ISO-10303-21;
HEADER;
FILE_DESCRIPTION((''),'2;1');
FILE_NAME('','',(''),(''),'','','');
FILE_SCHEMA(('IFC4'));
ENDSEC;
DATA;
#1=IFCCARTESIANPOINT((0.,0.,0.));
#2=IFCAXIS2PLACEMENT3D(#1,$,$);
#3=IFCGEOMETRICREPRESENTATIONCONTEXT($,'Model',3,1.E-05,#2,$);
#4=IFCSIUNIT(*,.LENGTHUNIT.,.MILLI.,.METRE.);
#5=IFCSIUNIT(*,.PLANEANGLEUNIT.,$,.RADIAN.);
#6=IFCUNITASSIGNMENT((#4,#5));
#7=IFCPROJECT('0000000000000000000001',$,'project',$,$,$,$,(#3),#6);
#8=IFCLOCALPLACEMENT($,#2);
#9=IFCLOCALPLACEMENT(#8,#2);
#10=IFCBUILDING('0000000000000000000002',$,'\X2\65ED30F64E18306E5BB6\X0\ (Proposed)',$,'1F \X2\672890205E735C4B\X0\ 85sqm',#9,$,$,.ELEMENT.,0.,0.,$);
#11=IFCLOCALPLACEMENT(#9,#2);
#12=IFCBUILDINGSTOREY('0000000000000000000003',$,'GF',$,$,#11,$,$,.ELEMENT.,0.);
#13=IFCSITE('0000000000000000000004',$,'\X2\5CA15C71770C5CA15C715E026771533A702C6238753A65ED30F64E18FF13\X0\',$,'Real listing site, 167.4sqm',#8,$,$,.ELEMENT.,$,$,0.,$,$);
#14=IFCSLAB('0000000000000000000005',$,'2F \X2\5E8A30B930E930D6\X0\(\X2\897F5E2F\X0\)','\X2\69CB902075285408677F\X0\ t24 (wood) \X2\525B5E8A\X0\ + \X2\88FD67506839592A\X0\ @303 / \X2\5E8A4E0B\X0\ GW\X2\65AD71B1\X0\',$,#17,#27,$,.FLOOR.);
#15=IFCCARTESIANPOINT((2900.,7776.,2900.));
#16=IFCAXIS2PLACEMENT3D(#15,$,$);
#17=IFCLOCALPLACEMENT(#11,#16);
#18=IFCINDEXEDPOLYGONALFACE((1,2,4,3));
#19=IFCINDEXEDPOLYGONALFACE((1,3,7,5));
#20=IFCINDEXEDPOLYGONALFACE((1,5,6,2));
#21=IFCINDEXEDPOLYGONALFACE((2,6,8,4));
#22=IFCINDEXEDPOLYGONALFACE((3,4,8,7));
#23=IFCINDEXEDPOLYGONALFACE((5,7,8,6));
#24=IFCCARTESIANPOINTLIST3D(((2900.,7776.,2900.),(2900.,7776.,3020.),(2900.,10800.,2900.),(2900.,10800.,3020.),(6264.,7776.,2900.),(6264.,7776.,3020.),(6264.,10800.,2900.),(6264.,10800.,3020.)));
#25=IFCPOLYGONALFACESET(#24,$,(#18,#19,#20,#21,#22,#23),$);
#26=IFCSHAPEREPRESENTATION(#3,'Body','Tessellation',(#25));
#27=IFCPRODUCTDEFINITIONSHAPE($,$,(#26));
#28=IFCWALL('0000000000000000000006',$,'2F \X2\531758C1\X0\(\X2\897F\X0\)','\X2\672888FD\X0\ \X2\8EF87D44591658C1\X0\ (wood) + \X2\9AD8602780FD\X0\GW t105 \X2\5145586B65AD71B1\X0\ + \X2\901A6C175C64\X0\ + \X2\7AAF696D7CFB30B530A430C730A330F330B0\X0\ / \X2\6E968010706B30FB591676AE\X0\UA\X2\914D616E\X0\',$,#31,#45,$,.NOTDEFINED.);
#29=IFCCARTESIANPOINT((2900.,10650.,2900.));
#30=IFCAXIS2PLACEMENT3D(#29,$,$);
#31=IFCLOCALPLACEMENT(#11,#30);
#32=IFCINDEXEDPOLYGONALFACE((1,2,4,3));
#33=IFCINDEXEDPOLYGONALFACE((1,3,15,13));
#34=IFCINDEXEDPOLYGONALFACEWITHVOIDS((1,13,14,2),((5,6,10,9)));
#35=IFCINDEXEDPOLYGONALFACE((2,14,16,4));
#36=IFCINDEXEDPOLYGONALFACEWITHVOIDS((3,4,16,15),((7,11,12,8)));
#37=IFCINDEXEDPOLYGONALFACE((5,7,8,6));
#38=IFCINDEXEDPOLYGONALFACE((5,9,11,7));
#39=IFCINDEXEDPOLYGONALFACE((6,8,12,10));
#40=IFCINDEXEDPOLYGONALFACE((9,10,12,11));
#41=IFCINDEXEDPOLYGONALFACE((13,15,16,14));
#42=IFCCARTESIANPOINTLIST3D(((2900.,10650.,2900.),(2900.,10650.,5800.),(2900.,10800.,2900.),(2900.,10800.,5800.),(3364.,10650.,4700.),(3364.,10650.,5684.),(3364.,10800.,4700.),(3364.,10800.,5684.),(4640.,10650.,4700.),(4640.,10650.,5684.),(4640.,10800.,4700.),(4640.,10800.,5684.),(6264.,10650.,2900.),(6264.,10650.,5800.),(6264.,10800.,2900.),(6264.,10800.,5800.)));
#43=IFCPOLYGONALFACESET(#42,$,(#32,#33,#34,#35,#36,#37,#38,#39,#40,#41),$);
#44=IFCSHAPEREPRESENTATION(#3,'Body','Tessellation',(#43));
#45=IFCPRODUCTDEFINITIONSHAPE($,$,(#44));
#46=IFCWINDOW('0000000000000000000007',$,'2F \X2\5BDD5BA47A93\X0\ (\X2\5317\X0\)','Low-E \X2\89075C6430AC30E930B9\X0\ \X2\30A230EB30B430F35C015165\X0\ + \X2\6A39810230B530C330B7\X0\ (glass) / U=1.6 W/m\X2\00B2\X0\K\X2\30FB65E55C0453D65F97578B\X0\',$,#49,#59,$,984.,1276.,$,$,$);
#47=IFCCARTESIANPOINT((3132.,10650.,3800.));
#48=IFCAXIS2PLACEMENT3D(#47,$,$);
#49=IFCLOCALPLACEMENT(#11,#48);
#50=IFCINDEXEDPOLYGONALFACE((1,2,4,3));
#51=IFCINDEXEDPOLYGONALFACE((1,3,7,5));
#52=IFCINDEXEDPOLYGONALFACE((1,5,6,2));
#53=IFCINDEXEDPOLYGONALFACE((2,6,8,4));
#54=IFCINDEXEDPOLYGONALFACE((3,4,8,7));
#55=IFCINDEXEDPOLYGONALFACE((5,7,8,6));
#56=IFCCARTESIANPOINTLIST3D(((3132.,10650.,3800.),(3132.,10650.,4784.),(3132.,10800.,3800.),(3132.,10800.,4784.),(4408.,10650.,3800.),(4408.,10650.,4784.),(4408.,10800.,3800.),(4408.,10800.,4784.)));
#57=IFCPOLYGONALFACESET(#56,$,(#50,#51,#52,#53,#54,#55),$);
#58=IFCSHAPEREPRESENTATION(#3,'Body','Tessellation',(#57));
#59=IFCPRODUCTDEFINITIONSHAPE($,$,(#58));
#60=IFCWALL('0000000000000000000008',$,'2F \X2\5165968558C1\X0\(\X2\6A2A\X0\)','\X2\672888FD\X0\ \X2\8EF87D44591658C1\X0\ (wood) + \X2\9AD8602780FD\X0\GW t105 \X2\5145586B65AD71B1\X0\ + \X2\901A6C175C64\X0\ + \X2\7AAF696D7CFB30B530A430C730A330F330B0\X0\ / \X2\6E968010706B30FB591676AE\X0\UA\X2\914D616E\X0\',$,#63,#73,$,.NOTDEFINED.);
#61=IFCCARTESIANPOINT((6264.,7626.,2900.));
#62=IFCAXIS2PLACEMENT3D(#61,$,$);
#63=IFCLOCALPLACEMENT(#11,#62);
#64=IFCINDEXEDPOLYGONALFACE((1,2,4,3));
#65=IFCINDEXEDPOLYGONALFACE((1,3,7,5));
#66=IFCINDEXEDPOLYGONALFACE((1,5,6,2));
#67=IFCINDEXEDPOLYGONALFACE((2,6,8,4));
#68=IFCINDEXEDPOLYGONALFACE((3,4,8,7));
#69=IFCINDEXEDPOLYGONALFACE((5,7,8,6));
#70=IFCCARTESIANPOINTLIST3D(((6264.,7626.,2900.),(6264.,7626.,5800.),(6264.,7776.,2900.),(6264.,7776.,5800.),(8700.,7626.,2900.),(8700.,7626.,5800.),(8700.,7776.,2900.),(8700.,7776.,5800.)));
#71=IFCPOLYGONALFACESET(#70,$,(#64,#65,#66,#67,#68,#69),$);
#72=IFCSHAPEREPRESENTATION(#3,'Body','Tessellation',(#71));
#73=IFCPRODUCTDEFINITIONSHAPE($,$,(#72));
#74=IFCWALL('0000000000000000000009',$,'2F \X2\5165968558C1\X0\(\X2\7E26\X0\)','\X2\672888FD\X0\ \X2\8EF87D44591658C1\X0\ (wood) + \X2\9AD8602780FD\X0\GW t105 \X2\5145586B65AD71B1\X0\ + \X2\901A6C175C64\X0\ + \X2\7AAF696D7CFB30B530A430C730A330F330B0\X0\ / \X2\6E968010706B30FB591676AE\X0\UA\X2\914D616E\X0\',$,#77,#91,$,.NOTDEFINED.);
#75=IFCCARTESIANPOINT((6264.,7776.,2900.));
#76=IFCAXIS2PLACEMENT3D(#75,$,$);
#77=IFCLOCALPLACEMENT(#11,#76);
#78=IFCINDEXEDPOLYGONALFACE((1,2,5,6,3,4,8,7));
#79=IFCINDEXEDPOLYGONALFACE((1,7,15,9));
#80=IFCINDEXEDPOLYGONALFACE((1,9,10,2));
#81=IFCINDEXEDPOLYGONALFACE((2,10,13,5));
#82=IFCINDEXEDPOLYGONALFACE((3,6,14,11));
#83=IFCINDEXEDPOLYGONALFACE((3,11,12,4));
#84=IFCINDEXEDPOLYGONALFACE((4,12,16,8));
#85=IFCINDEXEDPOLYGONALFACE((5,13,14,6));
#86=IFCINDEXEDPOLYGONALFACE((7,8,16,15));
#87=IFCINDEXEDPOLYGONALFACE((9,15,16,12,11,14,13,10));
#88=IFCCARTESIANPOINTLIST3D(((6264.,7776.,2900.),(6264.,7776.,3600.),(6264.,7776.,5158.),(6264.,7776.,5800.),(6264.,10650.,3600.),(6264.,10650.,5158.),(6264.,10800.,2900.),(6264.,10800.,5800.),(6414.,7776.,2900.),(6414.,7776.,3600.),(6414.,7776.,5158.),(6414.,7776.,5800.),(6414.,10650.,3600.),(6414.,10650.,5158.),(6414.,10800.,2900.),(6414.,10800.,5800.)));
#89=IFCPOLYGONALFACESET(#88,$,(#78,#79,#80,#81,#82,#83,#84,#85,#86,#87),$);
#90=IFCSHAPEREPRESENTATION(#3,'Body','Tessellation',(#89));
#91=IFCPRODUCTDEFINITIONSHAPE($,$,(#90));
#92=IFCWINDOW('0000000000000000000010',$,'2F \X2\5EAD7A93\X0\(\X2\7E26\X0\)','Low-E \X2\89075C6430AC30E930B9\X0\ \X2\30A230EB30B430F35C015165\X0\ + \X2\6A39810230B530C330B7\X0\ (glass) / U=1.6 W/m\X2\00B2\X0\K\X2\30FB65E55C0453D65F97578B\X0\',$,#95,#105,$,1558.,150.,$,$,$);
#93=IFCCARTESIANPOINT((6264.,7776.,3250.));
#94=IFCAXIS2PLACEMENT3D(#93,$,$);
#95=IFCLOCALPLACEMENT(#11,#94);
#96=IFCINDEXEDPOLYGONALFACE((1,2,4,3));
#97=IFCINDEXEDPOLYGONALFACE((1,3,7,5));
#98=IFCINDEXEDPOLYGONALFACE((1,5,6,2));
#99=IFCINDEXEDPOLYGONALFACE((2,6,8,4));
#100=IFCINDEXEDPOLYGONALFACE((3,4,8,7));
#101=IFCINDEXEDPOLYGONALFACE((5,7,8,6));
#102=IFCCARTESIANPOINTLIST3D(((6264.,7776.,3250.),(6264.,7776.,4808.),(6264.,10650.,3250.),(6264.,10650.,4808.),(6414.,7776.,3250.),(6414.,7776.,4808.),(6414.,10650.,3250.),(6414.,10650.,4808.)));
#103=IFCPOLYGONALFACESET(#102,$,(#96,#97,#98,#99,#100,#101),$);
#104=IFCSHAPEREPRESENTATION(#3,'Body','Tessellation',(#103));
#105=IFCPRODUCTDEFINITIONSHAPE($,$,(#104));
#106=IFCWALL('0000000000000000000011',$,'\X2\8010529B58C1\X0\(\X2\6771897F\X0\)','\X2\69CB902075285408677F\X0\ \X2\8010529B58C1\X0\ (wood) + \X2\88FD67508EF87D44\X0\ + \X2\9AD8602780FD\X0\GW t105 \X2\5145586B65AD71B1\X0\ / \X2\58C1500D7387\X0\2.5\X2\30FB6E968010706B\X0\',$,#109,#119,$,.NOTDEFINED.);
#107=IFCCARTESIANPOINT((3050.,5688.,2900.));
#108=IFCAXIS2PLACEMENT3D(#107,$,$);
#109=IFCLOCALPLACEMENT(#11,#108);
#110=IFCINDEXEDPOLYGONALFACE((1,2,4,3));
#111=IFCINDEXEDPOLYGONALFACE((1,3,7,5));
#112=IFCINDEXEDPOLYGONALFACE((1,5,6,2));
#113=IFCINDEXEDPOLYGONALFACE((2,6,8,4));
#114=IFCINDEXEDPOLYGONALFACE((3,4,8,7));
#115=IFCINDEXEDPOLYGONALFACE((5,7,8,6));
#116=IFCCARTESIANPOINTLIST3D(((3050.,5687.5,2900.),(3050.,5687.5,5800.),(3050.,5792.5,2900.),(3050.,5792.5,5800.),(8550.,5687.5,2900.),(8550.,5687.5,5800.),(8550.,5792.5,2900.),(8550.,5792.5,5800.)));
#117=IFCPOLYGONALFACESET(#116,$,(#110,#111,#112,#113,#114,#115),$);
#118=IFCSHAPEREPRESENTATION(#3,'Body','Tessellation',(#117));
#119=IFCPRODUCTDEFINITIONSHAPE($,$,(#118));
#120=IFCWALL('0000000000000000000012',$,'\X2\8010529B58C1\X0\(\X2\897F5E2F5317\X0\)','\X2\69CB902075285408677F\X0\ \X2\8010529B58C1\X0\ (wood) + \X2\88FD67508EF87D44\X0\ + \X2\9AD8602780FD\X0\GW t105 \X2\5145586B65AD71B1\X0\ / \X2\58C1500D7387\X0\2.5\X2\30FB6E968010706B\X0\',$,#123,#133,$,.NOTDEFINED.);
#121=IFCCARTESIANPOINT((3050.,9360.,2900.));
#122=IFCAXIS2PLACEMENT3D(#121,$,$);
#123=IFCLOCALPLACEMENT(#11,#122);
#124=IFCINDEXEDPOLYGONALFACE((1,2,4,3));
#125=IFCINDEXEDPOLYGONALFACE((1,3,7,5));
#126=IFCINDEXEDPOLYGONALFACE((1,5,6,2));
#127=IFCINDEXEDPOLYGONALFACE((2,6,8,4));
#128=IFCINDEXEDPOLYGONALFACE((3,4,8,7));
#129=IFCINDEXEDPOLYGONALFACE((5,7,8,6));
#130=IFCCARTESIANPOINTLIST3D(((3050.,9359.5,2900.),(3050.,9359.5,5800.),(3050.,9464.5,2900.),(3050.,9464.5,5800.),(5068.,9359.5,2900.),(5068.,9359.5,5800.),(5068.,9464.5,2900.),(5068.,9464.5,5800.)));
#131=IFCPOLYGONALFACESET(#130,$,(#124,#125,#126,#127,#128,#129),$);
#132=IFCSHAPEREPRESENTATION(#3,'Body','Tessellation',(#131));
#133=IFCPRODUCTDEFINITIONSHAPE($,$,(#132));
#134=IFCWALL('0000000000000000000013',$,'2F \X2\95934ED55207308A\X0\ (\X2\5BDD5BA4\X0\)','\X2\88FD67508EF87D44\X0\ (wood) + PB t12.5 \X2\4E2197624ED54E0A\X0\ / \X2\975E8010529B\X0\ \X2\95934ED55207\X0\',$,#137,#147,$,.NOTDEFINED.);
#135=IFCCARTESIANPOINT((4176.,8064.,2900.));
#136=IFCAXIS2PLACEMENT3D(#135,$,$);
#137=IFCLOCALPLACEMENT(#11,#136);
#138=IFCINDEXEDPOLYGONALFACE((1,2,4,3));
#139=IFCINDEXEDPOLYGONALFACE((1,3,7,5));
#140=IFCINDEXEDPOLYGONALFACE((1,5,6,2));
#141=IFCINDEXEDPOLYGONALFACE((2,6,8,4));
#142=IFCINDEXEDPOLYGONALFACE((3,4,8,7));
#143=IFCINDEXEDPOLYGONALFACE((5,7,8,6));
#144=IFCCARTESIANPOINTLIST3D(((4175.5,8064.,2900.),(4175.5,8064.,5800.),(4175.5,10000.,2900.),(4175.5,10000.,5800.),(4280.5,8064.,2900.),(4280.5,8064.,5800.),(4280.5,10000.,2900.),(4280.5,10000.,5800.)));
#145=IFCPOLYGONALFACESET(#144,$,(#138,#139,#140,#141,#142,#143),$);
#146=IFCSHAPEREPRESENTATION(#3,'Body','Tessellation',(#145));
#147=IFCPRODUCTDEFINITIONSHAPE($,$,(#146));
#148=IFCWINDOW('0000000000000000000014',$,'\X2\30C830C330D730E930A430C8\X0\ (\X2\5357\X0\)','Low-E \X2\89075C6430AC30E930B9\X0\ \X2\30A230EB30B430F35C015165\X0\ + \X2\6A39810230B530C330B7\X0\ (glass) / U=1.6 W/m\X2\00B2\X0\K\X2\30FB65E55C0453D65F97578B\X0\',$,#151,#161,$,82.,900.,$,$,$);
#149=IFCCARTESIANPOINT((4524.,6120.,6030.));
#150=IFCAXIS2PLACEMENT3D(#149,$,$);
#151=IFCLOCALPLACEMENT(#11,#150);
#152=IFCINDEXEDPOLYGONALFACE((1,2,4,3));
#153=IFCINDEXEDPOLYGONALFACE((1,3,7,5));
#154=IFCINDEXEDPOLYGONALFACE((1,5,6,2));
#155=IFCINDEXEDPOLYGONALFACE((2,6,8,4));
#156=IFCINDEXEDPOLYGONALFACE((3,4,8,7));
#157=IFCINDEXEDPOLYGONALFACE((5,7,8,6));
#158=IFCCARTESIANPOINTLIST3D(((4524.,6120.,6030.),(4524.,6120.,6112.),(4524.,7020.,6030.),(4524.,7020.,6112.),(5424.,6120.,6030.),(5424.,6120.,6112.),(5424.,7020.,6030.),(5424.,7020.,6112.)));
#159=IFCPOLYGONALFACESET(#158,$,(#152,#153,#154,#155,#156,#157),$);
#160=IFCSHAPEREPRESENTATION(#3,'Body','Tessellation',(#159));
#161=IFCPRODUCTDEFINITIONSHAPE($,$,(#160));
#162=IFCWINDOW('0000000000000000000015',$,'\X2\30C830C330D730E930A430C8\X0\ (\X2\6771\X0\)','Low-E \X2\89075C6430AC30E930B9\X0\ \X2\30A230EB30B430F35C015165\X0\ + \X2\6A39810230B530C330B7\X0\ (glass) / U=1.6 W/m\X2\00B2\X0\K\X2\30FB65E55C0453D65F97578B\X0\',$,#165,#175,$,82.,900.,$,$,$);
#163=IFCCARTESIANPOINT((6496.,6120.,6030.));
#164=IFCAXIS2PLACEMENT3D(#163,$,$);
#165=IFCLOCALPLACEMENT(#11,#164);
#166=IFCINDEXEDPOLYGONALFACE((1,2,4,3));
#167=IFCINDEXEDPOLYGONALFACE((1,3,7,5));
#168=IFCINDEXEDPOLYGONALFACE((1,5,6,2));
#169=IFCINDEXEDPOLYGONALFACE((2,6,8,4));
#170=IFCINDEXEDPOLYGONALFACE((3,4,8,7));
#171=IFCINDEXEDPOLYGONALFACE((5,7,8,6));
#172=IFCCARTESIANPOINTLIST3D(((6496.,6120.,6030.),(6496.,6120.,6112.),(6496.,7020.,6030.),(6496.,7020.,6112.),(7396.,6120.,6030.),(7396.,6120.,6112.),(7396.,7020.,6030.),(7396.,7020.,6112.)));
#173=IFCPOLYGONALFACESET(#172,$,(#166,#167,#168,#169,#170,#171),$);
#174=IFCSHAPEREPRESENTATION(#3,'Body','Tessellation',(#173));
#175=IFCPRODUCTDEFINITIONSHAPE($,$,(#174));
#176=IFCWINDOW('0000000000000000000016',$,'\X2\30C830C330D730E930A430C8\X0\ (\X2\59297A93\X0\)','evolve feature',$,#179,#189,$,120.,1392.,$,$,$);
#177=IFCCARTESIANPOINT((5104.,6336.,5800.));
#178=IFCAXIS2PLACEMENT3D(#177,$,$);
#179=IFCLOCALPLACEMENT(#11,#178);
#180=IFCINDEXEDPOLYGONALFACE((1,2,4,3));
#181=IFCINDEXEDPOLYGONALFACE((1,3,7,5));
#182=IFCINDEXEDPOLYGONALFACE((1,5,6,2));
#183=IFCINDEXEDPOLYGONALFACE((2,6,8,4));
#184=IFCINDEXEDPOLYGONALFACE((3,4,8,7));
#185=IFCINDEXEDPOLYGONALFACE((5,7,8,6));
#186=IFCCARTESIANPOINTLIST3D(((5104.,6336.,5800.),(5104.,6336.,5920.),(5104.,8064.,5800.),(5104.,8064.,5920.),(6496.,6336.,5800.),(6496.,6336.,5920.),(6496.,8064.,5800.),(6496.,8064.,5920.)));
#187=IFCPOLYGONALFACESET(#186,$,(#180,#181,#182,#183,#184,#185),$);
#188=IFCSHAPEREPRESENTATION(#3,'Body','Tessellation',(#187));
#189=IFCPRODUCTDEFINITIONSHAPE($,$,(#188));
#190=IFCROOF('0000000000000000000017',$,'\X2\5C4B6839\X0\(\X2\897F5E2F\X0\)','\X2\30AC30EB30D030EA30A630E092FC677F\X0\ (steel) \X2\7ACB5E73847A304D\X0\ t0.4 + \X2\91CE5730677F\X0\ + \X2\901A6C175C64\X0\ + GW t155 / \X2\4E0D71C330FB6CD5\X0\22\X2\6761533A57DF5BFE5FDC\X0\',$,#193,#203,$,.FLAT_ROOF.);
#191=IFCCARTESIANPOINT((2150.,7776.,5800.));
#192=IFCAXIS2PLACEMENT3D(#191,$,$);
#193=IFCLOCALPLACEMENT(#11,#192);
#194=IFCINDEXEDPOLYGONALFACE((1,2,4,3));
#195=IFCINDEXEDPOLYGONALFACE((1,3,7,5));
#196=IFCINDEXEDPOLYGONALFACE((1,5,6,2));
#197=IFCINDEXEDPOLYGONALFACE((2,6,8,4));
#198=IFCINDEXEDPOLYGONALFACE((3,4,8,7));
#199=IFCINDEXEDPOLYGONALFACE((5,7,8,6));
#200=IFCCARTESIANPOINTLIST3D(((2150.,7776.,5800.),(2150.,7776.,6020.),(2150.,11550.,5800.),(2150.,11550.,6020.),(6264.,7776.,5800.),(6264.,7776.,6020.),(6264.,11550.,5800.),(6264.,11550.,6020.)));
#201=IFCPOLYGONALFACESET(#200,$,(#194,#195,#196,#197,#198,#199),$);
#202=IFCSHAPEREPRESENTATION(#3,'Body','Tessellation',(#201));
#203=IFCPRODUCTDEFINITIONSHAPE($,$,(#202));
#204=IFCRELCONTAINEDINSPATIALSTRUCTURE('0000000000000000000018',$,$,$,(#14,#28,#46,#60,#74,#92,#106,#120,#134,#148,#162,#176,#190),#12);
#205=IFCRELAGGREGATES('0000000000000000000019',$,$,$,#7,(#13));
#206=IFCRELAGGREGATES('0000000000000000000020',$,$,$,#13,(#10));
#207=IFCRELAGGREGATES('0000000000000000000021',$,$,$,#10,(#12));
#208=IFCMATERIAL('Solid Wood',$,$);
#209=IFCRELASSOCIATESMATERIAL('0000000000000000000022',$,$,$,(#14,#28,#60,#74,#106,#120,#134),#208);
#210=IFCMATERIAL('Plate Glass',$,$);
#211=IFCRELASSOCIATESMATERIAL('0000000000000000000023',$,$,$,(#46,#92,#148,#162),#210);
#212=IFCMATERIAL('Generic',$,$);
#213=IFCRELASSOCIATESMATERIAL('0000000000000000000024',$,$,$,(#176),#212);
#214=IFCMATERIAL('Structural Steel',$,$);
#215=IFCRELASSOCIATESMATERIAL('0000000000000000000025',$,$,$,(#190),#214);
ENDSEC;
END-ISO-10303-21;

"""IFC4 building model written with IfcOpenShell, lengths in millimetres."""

from ifc_helpers import new_model, si_unit, frame, frame_2d, origin, place, context, project, spatial, rectangle, extrude, material, element, fill, save


model = new_model("IFC4")

# Units and contexts
model_context = context("Model", 3, precision=1e-05, world=origin())
ifc_project = project(units=[si_unit("LENGTHUNIT", "METRE", prefix="MILLI"), si_unit("PLANEANGLEUNIT", "RADIAN")], contexts=[model_context])

# Site, building, storey
site_placement = place(None, origin())
site = spatial("IfcSite", under=ifc_project, at=site_placement, Name="岡山県岡山市東区瀬戸町旭ヶ丘３", ObjectType="Real listing site, 167.4sqm", CompositionType="ELEMENT", RefElevation=0.0)
building_placement = place(site_placement, origin())
building = spatial("IfcBuilding", under=site, at=building_placement, Name="旭ヶ丘の家 (Proposed)", ObjectType="1F 木造平屋 85sqm", CompositionType="ELEMENT", ElevationOfRefHeight=0.0, ElevationOfTerrain=0.0)
storey_placement = place(building_placement, origin())
storey = spatial("IfcBuildingStorey", under=building, at=storey_placement, Name="GF", CompositionType="ELEMENT", Elevation=0.0)

# Slab
ifc_material_1 = material(Name="Solid Wood")
slab_placement = place(storey_placement, frame((2900.0, 7776.0, 2900.0)))
element("IfcSlab", 1, at=slab_placement, inside=storey, material=ifc_material_1, Name="2F 床スラブ(西帯)", Description="構造用合板 t24 (wood) 剛床 + 製材根太 @303 / 床下 GW断熱", PredefinedType="FLOOR", context=model_context, shape_type="SweptSolid", body=[
    extrude(rectangle(XDim=3364.0, YDim=3024.0, at=frame_2d((1682.0, 1512.0))), frame((2900.0, 7776.0, 2900.0)), (0.0, 0.0, 1.0), 120.0),
])

# Wall, opening, window
wall_1_placement = place(storey_placement, frame((2900.0, 10650.0, 2900.0)))
wall_1 = element("IfcWall", 2, at=wall_1_placement, inside=storey, material=ifc_material_1, Name="2F 北壁(西)", Description="木製 軸組外壁 (wood) + 高性能GW t105 充填断熱 + 通気層 + 窯業系サイディング / 準耐火・外皮UA配慮", PredefinedType="NOTDEFINED", context=model_context, shape_type="SweptSolid", body=[
    extrude(rectangle(XDim=3364.0, YDim=150.0, at=frame_2d((1682.0, 75.0))), frame((2900.0, 10650.0, 2900.0)), (0.0, 0.0, 1.0), 2900.0),
])
opening_1_placement = place(storey_placement, frame((3132.0, 10650.0, 3800.0)))
opening_1 = element("IfcOpeningElement", 3, at=opening_1_placement, cuts=wall_1, PredefinedType="NOTDEFINED", context=model_context, shape_type="SweptSolid", body=[
    extrude(rectangle(XDim=1276.0, YDim=150.0, at=frame_2d((638.0, 75.0))), frame((3132.0, 10650.0, 3800.0)), (0.0, 0.0, 1.0), 984.0),
])
ifc_material_2 = material(Name="Plate Glass")
window_1_placement = place(storey_placement, frame((3132.0, 10650.0, 3800.0)))
window_1 = element("IfcWindow", 4, at=window_1_placement, inside=storey, material=ifc_material_2, Name="2F 寝室窓 (北)", Description="Low-E 複層ガラス アルゴン封入 + 樹脂サッシ (glass) / U=1.6 W/m²K・日射取得型", OverallHeight=984.0, OverallWidth=1276.0, context=model_context, shape_type="SweptSolid", body=[
    extrude(rectangle(XDim=1276.0, YDim=150.0, at=frame_2d((638.0, 75.0))), frame((3132.0, 10650.0, 3800.0)), (0.0, 0.0, 1.0), 984.0),
])
fill(opening_1, window_1)

# Wall
wall_2_placement = place(storey_placement, frame((6264.0, 7626.0, 2900.0)))
element("IfcWall", 5, at=wall_2_placement, inside=storey, material=ifc_material_1, Name="2F 入隅壁(横)", Description="木製 軸組外壁 (wood) + 高性能GW t105 充填断熱 + 通気層 + 窯業系サイディング / 準耐火・外皮UA配慮", PredefinedType="NOTDEFINED", context=model_context, shape_type="SweptSolid", body=[
    extrude(rectangle(XDim=2436.0, YDim=150.0, at=frame_2d((1218.0, 75.0))), frame((6264.0, 7626.0, 2900.0)), (0.0, 0.0, 1.0), 2900.0),
])

# Wall, opening, window
wall_3_placement = place(storey_placement, frame((6264.0, 7776.0, 2900.0)))
wall_3 = element("IfcWall", 6, at=wall_3_placement, inside=storey, material=ifc_material_1, Name="2F 入隅壁(縦)", Description="木製 軸組外壁 (wood) + 高性能GW t105 充填断熱 + 通気層 + 窯業系サイディング / 準耐火・外皮UA配慮", PredefinedType="NOTDEFINED", context=model_context, shape_type="SweptSolid", body=[
    extrude(rectangle(XDim=150.0, YDim=3024.0, at=frame_2d((75.0, 1512.0))), frame((6264.0, 7776.0, 2900.0)), (0.0, 0.0, 1.0), 2900.0),
])
opening_2_placement = place(storey_placement, frame((6264.0, 7776.0, 3250.0)))
opening_2 = element("IfcOpeningElement", 7, at=opening_2_placement, cuts=wall_3, PredefinedType="NOTDEFINED", context=model_context, shape_type="SweptSolid", body=[
    extrude(rectangle(XDim=150.0, YDim=2874.0, at=frame_2d((75.0, 1437.0))), frame((6264.0, 7776.0, 3250.0)), (0.0, 0.0, 1.0), 1558.0),
])
window_2_placement = place(storey_placement, frame((6264.0, 7776.0, 3250.0)))
window_2 = element("IfcWindow", 8, at=window_2_placement, inside=storey, material=ifc_material_2, Name="2F 庭窓(縦)", Description="Low-E 複層ガラス アルゴン封入 + 樹脂サッシ (glass) / U=1.6 W/m²K・日射取得型", OverallHeight=1558.0, OverallWidth=150.0, context=model_context, shape_type="SweptSolid", body=[
    extrude(rectangle(XDim=150.0, YDim=2874.0, at=frame_2d((75.0, 1437.0))), frame((6264.0, 7776.0, 3250.0)), (0.0, 0.0, 1.0), 1558.0),
])
fill(opening_2, window_2)

# Walls
wall_4_placement = place(storey_placement, frame((3050.0, 5688.0, 2900.0)))
element("IfcWall", 9, at=wall_4_placement, inside=storey, material=ifc_material_1, Name="耐力壁(東西)", Description="構造用合板 耐力壁 (wood) + 製材軸組 + 高性能GW t105 充填断熱 / 壁倍率2.5・準耐火", PredefinedType="NOTDEFINED", context=model_context, shape_type="SweptSolid", body=[
    extrude(rectangle(XDim=5500.0, YDim=105.0, at=frame_2d((2750.0, 52.0))), frame((3050.0, 5688.0, 2900.0)), (0.0, 0.0, 1.0), 2900.0),
])
wall_5_placement = place(storey_placement, frame((3050.0, 9360.0, 2900.0)))
element("IfcWall", 10, at=wall_5_placement, inside=storey, material=ifc_material_1, Name="耐力壁(西帯北)", Description="構造用合板 耐力壁 (wood) + 製材軸組 + 高性能GW t105 充填断熱 / 壁倍率2.5・準耐火", PredefinedType="NOTDEFINED", context=model_context, shape_type="SweptSolid", body=[
    extrude(rectangle(XDim=2018.0, YDim=105.0, at=frame_2d((1009.0, 52.0))), frame((3050.0, 9360.0, 2900.0)), (0.0, 0.0, 1.0), 2900.0),
])
wall_6_placement = place(storey_placement, frame((4176.0, 8064.0, 2900.0)))
element("IfcWall", 11, at=wall_6_placement, inside=storey, material=ifc_material_1, Name="2F 間仕切り (寝室)", Description="製材軸組 (wood) + PB t12.5 両面仕上 / 非耐力 間仕切", PredefinedType="NOTDEFINED", context=model_context, shape_type="SweptSolid", body=[
    extrude(rectangle(XDim=105.0, YDim=1936.0, at=frame_2d((52.0, 968.0))), frame((4176.0, 8064.0, 2900.0)), (0.0, 0.0, 1.0), 2900.0),
])

# Windows
window_3_placement = place(storey_placement, frame((4524.0, 6120.0, 6030.0)))
element("IfcWindow", 12, at=window_3_placement, inside=storey, material=ifc_material_2, Name="トップライト (南)", Description="Low-E 複層ガラス アルゴン封入 + 樹脂サッシ (glass) / U=1.6 W/m²K・日射取得型", OverallHeight=82.0, OverallWidth=900.0, context=model_context, shape_type="SweptSolid", body=[
    extrude(rectangle(XDim=900.0, YDim=900.0, at=frame_2d((450.0, 450.0))), frame((4524.0, 6120.0, 6030.0)), (0.0, 0.0, 1.0), 82.0),
])
window_4_placement = place(storey_placement, frame((6496.0, 6120.0, 6030.0)))
element("IfcWindow", 13, at=window_4_placement, inside=storey, material=ifc_material_2, Name="トップライト (東)", Description="Low-E 複層ガラス アルゴン封入 + 樹脂サッシ (glass) / U=1.6 W/m²K・日射取得型", OverallHeight=82.0, OverallWidth=900.0, context=model_context, shape_type="SweptSolid", body=[
    extrude(rectangle(XDim=900.0, YDim=900.0, at=frame_2d((450.0, 450.0))), frame((6496.0, 6120.0, 6030.0)), (0.0, 0.0, 1.0), 82.0),
])
ifc_material_3 = material(Name="Generic")
window_5_placement = place(storey_placement, frame((5104.0, 6336.0, 5800.0)))
element("IfcWindow", 14, at=window_5_placement, inside=storey, material=ifc_material_3, Name="トップライト (天窓)", Description="evolve feature", OverallHeight=120.0, OverallWidth=1392.0, context=model_context, shape_type="SweptSolid", body=[
    extrude(rectangle(XDim=1392.0, YDim=1728.0, at=frame_2d((696.0, 864.0))), frame((5104.0, 6336.0, 5800.0)), (0.0, 0.0, 1.0), 120.0),
])

# Roof
ifc_material_4 = material(Name="Structural Steel")
for number, where, name in (
    (15, (2150.0, 7776.0, 5800.0), "屋根(西帯)"),
):
    element("IfcRoof", number, at=place(storey_placement, frame(where)), inside=storey, material=ifc_material_4, Name=name, Description="ガルバリウム鋼板 (steel) 立平葺き t0.4 + 野地板 + 通気層 + GW t155 / 不燃・法22条区域対応", PredefinedType="FLAT_ROOF", context=model_context, shape_type="SweptSolid", body=[
        extrude(rectangle(XDim=4114.0, YDim=3774.0, at=frame_2d((2057.0, 1887.0))), frame((2150.0, 7776.0, 5800.0)), (0.0, 0.0, 1.0), 220.0),
    ])

save(model, "model.ifc")
